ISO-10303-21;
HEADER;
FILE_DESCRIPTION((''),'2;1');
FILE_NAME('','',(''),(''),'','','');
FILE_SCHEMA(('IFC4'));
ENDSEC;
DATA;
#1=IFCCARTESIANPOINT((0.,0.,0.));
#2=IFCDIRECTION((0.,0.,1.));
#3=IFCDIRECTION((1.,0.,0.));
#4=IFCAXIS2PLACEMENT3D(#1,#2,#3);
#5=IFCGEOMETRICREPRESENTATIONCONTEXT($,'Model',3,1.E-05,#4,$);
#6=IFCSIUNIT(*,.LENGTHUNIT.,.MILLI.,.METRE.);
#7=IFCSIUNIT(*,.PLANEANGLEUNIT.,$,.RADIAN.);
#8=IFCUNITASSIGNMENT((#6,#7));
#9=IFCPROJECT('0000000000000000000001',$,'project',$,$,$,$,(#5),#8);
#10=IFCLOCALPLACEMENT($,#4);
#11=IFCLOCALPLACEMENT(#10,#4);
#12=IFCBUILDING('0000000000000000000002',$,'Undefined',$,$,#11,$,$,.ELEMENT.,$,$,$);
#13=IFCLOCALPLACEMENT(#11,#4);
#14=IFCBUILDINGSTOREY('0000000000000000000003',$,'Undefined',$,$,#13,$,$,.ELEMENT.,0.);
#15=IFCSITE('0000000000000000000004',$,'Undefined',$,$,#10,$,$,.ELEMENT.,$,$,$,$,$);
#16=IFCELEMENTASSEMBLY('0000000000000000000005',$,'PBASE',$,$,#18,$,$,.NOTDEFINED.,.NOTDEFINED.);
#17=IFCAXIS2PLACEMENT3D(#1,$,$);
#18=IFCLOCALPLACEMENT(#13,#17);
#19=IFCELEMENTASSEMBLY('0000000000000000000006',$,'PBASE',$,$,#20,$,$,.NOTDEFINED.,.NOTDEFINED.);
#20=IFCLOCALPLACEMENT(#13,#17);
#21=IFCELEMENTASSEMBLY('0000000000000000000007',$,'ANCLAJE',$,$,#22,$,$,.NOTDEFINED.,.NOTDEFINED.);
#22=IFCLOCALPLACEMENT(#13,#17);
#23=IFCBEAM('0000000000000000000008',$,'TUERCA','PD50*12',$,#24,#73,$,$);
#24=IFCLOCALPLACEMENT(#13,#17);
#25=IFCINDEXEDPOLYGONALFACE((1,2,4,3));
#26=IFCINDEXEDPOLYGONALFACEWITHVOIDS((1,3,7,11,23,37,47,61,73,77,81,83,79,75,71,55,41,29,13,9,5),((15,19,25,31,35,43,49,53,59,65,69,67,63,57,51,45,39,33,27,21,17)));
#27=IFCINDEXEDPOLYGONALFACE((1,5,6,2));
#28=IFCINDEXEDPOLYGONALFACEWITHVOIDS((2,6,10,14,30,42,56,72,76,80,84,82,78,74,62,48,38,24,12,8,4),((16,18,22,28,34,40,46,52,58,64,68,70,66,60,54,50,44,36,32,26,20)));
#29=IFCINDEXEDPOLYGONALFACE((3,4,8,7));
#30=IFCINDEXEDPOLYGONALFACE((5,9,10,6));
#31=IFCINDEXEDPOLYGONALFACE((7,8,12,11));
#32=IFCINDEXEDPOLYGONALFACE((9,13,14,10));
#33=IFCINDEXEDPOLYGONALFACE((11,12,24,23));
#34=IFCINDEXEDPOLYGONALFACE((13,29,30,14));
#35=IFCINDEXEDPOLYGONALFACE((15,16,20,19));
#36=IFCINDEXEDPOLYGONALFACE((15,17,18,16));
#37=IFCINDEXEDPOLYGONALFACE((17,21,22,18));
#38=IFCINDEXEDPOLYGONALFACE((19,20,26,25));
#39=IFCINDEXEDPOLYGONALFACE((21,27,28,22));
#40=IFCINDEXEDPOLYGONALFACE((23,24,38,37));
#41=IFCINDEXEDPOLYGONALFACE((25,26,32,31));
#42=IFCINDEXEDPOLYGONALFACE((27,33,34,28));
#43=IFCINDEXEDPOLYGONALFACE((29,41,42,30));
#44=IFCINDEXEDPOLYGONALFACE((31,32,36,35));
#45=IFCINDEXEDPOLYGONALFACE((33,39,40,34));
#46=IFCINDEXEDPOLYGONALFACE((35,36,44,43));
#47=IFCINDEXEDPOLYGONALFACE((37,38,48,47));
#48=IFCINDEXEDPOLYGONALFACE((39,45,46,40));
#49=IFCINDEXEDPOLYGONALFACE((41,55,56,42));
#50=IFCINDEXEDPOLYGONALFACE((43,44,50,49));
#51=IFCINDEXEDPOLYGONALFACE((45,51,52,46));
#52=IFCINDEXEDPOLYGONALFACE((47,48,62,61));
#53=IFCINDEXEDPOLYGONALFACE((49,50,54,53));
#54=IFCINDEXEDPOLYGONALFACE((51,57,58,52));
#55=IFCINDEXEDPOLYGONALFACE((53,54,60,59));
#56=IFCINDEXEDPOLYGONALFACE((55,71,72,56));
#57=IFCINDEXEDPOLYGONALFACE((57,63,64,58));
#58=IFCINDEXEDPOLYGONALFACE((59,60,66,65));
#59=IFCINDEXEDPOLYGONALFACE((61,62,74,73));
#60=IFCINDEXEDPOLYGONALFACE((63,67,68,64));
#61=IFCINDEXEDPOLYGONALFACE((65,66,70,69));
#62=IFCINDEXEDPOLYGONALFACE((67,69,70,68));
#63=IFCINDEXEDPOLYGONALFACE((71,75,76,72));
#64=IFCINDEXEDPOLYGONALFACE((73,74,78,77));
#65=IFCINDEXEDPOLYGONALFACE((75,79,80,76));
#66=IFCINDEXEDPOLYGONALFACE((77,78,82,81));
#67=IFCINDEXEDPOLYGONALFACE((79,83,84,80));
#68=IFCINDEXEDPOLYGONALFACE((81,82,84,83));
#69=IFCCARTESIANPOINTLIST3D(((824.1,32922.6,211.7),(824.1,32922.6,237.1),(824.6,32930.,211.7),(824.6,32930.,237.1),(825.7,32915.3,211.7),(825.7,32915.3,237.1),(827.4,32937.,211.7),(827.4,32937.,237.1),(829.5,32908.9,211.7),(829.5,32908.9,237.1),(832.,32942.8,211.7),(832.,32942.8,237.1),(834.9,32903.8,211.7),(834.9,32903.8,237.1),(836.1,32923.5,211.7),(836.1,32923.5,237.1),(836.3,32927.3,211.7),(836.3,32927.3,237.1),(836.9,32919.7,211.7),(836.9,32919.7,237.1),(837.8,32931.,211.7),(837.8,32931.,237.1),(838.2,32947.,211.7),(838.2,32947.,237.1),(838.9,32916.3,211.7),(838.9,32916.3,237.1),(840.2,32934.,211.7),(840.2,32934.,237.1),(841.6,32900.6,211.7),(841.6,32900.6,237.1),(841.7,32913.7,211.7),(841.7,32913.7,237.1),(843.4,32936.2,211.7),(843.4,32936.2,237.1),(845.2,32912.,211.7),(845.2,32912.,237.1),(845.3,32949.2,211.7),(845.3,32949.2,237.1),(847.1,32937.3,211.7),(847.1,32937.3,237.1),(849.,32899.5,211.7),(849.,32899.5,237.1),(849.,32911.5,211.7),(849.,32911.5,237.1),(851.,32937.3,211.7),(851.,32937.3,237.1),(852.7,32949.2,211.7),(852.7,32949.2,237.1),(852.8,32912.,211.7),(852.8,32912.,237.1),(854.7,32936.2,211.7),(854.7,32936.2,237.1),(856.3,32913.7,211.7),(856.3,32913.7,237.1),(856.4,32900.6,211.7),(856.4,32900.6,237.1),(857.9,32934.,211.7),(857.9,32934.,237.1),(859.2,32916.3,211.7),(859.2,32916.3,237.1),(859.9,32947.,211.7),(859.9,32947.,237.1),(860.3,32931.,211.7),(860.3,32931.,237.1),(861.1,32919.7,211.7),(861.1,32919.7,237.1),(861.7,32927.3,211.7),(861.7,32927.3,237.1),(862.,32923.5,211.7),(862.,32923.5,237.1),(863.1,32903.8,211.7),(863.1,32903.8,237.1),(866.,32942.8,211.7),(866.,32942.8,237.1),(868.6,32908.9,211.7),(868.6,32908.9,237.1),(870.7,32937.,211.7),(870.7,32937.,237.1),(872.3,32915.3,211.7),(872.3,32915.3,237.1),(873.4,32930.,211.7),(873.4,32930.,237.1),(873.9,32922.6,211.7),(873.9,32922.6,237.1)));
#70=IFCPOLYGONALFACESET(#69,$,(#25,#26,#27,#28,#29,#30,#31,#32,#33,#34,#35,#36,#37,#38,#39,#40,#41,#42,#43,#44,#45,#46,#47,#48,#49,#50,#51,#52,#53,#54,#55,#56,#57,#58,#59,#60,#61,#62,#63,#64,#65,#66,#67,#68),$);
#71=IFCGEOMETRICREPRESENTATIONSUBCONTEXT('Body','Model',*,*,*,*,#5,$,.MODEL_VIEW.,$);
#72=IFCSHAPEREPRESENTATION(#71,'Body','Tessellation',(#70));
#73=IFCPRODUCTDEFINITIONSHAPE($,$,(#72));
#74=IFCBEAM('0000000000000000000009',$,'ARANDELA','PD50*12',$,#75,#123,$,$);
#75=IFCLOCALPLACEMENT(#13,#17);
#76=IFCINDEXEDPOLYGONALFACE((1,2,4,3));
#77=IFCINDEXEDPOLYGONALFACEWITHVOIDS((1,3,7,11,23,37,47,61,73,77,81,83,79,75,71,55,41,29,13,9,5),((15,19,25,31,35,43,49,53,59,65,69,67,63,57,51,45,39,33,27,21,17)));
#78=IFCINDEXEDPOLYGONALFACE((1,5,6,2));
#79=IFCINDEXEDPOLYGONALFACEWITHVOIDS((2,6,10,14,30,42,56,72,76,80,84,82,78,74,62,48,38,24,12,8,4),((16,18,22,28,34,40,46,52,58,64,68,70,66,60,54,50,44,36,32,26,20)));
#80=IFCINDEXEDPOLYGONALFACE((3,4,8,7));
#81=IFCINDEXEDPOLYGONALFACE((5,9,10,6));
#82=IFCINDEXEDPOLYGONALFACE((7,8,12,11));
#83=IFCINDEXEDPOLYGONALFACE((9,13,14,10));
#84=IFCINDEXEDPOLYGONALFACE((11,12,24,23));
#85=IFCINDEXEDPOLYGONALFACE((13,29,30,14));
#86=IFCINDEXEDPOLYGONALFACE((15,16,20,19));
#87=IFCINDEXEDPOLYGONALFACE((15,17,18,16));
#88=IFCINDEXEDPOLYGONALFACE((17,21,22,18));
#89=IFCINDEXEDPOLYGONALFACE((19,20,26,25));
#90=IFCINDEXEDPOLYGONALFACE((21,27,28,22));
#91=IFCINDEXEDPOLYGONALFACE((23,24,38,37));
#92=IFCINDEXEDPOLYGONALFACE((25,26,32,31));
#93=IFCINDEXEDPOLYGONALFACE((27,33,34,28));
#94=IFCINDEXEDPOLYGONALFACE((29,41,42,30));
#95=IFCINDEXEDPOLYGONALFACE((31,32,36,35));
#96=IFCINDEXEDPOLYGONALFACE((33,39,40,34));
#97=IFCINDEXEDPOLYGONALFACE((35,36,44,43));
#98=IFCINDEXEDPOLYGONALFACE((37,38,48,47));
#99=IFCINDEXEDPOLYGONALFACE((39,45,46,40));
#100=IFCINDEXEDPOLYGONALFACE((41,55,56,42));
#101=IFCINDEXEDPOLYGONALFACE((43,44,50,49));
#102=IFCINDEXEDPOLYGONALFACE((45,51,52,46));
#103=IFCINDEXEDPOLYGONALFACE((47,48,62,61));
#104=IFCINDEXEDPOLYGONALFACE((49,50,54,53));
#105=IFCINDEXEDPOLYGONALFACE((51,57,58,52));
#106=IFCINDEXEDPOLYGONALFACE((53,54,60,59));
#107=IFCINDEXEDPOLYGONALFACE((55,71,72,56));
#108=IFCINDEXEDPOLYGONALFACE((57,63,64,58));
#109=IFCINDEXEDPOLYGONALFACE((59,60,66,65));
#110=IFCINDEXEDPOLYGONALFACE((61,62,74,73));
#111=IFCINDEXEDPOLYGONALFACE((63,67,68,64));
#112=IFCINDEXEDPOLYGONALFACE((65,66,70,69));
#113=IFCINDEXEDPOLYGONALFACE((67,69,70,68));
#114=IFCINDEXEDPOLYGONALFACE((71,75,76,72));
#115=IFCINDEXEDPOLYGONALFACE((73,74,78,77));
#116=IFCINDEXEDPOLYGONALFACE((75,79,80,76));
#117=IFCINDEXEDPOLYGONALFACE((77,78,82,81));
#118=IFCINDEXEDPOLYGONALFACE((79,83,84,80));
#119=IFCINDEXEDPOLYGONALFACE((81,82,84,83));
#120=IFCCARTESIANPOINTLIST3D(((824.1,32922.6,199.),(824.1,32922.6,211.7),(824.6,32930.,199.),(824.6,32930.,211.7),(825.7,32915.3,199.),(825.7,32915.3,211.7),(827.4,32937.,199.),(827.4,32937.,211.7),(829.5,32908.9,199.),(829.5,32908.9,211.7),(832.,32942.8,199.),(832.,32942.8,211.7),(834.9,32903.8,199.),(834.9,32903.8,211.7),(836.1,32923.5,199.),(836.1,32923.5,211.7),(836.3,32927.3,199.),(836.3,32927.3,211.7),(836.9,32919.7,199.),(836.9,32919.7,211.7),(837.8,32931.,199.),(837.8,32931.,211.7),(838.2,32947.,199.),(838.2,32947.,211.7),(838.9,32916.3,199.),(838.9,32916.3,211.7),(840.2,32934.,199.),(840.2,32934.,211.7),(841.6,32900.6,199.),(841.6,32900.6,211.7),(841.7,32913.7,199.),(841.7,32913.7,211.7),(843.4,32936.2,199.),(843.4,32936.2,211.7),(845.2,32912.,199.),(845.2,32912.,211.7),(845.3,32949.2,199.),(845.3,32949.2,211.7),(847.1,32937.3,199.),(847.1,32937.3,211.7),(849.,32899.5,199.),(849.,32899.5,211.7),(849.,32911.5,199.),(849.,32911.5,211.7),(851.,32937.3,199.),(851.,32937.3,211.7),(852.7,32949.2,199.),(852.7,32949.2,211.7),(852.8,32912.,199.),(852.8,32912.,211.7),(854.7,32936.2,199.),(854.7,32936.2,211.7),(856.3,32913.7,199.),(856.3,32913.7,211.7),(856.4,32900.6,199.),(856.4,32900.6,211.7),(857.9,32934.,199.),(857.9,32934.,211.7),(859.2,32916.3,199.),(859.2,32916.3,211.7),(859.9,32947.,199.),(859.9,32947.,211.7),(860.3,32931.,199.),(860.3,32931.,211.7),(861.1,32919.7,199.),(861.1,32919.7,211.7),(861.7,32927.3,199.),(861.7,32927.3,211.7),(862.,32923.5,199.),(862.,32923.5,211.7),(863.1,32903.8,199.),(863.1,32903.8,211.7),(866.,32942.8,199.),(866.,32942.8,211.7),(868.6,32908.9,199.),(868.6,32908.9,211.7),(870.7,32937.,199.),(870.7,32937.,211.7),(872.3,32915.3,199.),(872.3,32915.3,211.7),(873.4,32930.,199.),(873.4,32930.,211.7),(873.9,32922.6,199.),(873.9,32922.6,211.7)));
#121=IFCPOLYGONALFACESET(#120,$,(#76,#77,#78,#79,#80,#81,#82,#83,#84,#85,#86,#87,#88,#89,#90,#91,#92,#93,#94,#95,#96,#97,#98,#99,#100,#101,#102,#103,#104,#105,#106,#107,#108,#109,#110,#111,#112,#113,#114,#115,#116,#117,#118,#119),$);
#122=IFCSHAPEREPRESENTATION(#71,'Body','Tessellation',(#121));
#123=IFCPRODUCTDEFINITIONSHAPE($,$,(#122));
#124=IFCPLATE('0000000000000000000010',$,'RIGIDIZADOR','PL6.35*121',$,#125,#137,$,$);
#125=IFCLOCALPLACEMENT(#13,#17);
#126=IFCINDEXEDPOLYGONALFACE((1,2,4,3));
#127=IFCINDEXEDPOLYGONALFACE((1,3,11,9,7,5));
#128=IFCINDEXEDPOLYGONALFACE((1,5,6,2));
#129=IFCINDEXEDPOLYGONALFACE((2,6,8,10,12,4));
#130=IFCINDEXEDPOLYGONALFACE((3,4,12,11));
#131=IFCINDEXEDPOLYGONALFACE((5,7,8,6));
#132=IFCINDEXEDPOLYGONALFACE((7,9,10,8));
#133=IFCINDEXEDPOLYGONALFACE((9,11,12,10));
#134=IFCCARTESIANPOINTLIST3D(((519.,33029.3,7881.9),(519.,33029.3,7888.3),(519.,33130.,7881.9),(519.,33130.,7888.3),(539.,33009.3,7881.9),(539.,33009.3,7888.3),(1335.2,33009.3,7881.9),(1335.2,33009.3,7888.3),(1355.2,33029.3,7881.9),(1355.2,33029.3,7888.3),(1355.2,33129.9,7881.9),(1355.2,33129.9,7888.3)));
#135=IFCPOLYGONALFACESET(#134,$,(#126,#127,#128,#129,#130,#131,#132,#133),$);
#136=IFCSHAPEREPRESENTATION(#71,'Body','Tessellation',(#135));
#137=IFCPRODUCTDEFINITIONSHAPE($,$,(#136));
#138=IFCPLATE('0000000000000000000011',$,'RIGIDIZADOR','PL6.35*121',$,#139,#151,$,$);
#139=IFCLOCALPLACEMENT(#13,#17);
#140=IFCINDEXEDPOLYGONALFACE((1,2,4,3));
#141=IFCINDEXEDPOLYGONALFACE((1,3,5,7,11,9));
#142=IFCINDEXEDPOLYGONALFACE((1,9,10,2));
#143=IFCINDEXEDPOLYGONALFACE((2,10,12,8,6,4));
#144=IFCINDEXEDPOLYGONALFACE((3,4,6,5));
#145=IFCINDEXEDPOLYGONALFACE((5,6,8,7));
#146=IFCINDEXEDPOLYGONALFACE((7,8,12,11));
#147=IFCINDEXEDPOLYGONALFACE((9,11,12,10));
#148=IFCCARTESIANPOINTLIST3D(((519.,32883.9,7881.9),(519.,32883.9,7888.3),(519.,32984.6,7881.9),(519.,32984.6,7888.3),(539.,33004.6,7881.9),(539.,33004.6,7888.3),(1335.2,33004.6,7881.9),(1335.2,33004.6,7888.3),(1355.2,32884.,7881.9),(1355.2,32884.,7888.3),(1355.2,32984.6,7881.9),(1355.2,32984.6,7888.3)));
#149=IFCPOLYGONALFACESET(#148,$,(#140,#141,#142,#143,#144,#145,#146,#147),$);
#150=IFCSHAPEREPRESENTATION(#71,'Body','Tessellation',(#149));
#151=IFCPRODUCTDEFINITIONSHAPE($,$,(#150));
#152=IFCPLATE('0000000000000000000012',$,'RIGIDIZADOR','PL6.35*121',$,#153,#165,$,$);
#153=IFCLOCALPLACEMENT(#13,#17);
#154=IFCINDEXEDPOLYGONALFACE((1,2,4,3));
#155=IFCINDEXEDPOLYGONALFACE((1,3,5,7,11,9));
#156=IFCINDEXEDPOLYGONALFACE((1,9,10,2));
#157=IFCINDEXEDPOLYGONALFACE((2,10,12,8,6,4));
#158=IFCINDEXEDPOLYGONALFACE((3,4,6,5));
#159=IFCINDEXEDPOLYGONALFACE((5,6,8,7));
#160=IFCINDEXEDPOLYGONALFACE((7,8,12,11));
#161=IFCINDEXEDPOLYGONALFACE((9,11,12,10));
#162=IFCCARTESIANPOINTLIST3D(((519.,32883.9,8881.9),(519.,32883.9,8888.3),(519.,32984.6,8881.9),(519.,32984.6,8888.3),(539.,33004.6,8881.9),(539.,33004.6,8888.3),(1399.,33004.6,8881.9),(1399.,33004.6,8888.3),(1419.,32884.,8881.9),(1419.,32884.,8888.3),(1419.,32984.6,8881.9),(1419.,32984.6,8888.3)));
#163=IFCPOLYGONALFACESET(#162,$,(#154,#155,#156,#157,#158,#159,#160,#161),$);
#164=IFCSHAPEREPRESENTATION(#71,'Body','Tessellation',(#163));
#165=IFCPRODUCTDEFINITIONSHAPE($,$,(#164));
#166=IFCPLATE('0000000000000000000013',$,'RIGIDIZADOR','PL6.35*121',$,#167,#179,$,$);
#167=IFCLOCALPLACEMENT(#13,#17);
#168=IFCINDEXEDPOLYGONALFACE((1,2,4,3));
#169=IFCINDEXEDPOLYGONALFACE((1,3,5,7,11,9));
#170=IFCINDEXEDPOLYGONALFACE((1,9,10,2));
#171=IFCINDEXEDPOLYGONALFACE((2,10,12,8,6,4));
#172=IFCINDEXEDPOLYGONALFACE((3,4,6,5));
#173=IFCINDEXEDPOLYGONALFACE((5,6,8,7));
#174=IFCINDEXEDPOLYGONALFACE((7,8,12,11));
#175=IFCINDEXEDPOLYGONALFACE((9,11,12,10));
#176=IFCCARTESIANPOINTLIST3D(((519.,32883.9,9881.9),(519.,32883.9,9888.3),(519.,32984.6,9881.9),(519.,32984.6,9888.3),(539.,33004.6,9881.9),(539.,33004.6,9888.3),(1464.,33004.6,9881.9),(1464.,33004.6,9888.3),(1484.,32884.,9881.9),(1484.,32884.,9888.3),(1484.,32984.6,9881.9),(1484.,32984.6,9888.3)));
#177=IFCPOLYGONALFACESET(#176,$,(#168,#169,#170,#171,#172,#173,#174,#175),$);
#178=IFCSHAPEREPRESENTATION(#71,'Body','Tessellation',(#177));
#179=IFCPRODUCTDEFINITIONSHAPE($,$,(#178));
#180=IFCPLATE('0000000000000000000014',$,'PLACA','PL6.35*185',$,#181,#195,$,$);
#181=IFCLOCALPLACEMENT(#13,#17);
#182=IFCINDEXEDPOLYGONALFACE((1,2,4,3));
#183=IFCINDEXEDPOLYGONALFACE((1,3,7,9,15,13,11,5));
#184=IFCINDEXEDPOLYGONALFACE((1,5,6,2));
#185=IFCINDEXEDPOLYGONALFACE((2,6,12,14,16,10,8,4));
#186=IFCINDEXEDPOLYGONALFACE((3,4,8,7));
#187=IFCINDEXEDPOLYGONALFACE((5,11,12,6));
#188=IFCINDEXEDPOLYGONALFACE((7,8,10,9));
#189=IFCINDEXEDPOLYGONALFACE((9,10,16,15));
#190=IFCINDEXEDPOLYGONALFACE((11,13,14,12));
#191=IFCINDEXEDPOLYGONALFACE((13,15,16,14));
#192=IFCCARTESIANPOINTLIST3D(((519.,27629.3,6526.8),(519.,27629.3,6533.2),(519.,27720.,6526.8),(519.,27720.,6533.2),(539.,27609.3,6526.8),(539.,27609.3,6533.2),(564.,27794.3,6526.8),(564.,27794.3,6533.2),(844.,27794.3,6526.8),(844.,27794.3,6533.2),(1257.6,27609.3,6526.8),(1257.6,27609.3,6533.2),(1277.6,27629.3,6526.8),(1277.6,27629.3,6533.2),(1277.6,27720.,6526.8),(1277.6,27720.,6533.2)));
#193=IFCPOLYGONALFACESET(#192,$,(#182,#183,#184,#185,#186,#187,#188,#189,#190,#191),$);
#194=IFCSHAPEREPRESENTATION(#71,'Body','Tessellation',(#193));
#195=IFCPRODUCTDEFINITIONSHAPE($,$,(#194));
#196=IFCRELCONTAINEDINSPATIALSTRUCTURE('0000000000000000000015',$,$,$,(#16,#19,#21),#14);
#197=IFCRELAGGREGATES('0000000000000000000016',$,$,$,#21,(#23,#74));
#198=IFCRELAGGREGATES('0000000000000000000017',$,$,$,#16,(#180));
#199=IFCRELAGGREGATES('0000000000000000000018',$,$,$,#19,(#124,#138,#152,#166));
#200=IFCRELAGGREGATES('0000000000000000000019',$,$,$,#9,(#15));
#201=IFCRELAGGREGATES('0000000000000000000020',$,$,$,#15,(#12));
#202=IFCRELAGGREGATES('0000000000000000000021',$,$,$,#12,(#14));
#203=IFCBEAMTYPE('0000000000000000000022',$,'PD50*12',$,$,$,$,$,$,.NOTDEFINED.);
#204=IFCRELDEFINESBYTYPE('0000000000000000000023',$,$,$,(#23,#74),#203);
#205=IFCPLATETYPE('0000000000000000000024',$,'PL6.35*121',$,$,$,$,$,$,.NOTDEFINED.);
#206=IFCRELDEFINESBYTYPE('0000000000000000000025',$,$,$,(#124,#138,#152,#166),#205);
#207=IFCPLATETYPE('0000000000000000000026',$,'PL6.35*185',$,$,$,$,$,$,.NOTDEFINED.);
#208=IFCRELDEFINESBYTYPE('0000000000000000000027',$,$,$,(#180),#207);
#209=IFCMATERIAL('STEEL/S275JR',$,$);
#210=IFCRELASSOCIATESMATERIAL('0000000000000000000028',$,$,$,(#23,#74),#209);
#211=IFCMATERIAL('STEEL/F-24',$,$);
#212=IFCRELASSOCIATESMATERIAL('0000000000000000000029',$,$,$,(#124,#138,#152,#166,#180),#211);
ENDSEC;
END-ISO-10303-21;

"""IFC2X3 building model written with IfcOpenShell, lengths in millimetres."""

from ifc_helpers import new_model, si_unit, frame, origin_with_axes, origin_2d_with_axis, place, context, subcontext, project, spatial, polyline, hollow_circle, outline, extrude, material, type_object, element, aggregate, save


model = new_model("IFC2X3")

# Units and contexts
model_context = context("Model", 3, precision=1e-05, world=origin_with_axes())
body_context = subcontext(model_context, "Body", "Model", "MODEL_VIEW")
ifc_project = project(units=[si_unit("LENGTHUNIT", "METRE", prefix="MILLI"), si_unit("PLANEANGLEUNIT", "RADIAN")], contexts=[model_context])

# Site, building, storey
site_placement = place(None, origin_with_axes())
site = spatial("IfcSite", under=ifc_project, at=site_placement, Name="Undefined", CompositionType="ELEMENT")
building_placement = place(site_placement, origin_with_axes())
building = spatial("IfcBuilding", under=site, at=building_placement, Name="Undefined", CompositionType="ELEMENT")
storey_placement = place(building_placement, origin_with_axes())
storey = spatial("IfcBuildingStorey", under=building, at=storey_placement, Name="Undefined", CompositionType="ELEMENT", Elevation=0.0)

# Shared definitions
ifc_material_1 = material(Name="STEEL/F-24")

# Element assemblies
assembly_1_placement = place(storey_placement, origin_with_axes())
assembly_1 = element("IfcElementAssembly", 1, at=assembly_1_placement, inside=storey, Name="PBASE", AssemblyPlace="NOTDEFINED", PredefinedType="NOTDEFINED")
assembly_2_placement = place(storey_placement, origin_with_axes())
assembly_2 = element("IfcElementAssembly", 2, at=assembly_2_placement, inside=storey, Name="PBASE", AssemblyPlace="NOTDEFINED", PredefinedType="NOTDEFINED")

# Element assembly, beams
assembly_3_placement = place(storey_placement, origin_with_axes())
assembly_3 = element("IfcElementAssembly", 3, at=assembly_3_placement, inside=storey, Name="ANCLAJE", AssemblyPlace="NOTDEFINED", PredefinedType="NOTDEFINED")
ifc_material_2 = material(Name="STEEL/S275JR")
beam_type_1 = type_object("IfcBeamType", Name="PD50*12", PredefinedType="NOTDEFINED")
beam_1_placement = place(assembly_3_placement, frame((849.0, 32924.5, 237.1), z_axis=(1.0, 0.0, 0.0), x_axis=(0.0, 0.0, -1.0)))
beam_1 = element("IfcBeam", 4, at=beam_1_placement, type_object=beam_type_1, material=ifc_material_2, Name="TUERCA", Description="PD50*12", context=body_context, shape_type="SweptSolid", body=[
    extrude(hollow_circle(Radius=25.0, WallThickness=12.0, at=origin_2d_with_axis()), frame((25.4, 0.0, 0.0), z_axis=(-1.0, 0.0, 0.0), x_axis=(0.0, -1.0, 0.0)), (0.0, 0.0, 1.0), 25.4),
])
beam_2_placement = place(assembly_3_placement, frame((849.0, 32924.5, 211.7), z_axis=(1.0, 0.0, 0.0), x_axis=(0.0, 0.0, -1.0)))
beam_2 = element("IfcBeam", 5, at=beam_2_placement, type_object=beam_type_1, material=ifc_material_2, Name="ARANDELA", Description="PD50*12", context=body_context, shape_type="SweptSolid", body=[
    extrude(hollow_circle(Radius=25.0, WallThickness=12.0, at=origin_2d_with_axis()), frame((12.7, 0.0, 0.0), z_axis=(-1.0, 0.0, 0.0), x_axis=(0.0, -1.0, 0.0)), (0.0, 0.0, 1.0), 12.7),
])
aggregate(assembly_3, [beam_1, beam_2])

# Plates
plate_type_1 = type_object("IfcPlateType", Name="PL6.35*121", PredefinedType="NOTDEFINED")
plate_1_placement = place(assembly_2_placement, frame((519.0, 33009.3, 7885.1), z_axis=(0.0, 0.0, -1.0), x_axis=(0.0, 1.0, 0.0)))
plate_1 = element("IfcPlate", 6, at=plate_1_placement, type_object=plate_type_1, material=ifc_material_1, Name="RIGIDIZADOR", Description="PL6.35*121", context=body_context, shape_type="SweptSolid", body=[
    extrude(outline(polyline([(0.0, 20.0), (20.0, 0.0), (120.6, 0.0), (120.6, 836.2), (20.0, 836.2), (0.0, 816.2), (0.0, 20.0)])), frame((0.0, 0.0, -3.2), z_axis=(0.0, 0.0, 1.0), x_axis=(1.0, 0.0, 0.0)), (0.0, 0.0, 1.0), 6.4),
])
plate_2_placement = place(assembly_2_placement, frame((519.0, 33004.6, 7885.1), z_axis=(0.0, 0.0, 1.0), x_axis=(0.0, -1.0, 0.0)))
plate_2 = element("IfcPlate", 7, at=plate_2_placement, type_object=plate_type_1, material=ifc_material_1, Name="RIGIDIZADOR", Description="PL6.35*121", context=body_context, shape_type="SweptSolid", body=[
    extrude(outline(polyline([(0.0, 20.0), (20.0, 0.0), (120.6, 0.0), (120.6, 836.2), (20.0, 836.2), (0.0, 816.2), (0.0, 20.0)])), frame((0.0, 0.0, -3.2), z_axis=(0.0, 0.0, 1.0), x_axis=(1.0, 0.0, 0.0)), (0.0, 0.0, 1.0), 6.4),
])
plate_3_placement = place(assembly_2_placement, frame((519.0, 33004.6, 8885.1), z_axis=(0.0, 0.0, 1.0), x_axis=(0.0, -1.0, 0.0)))
plate_3 = element("IfcPlate", 8, at=plate_3_placement, type_object=plate_type_1, material=ifc_material_1, Name="RIGIDIZADOR", Description="PL6.35*121", context=body_context, shape_type="SweptSolid", body=[
    extrude(outline(polyline([(0.0, 20.0), (20.0, 0.0), (120.6, 0.0), (120.6, 900.0), (20.0, 900.0), (0.0, 880.0), (0.0, 20.0)])), frame((0.0, 0.0, -3.2), z_axis=(0.0, 0.0, 1.0), x_axis=(1.0, 0.0, 0.0)), (0.0, 0.0, 1.0), 6.4),
])
plate_4_placement = place(assembly_2_placement, frame((519.0, 33004.6, 9885.1), z_axis=(0.0, 0.0, 1.0), x_axis=(0.0, -1.0, 0.0)))
plate_4 = element("IfcPlate", 9, at=plate_4_placement, type_object=plate_type_1, material=ifc_material_1, Name="RIGIDIZADOR", Description="PL6.35*121", context=body_context, shape_type="SweptSolid", body=[
    extrude(outline(polyline([(0.0, 20.0), (20.0, 0.0), (120.6, 0.0), (120.6, 965.0), (20.0, 965.0), (0.0, 945.0), (0.0, 20.0)])), frame((0.0, 0.0, -3.2), z_axis=(0.0, 0.0, 1.0), x_axis=(1.0, 0.0, 0.0)), (0.0, 0.0, 1.0), 6.4),
])
plate_type_2 = type_object("IfcPlateType", Name="PL6.35*185", PredefinedType="NOTDEFINED")
plate_5_placement = place(assembly_1_placement, frame((519.0, 27720.0, 6530.0), z_axis=(-0.000012, 0.0, 1.0), x_axis=(0.0, -1.0, 0.0)))
plate_5 = element("IfcPlate", 10, at=plate_5_placement, type_object=plate_type_2, material=ifc_material_1, Name="PLACA", Description="PL6.35*185", context=body_context, shape_type="SweptSolid", body=[
    extrude(outline(polyline([(0.0, 0.0), (90.6, 0.0), (110.6, 20.0), (110.6, 738.6), (90.6, 758.6), (0.0, 758.6), (-74.3, 325.0), (-74.3, 45.0), (0.0, 0.0)])), frame((0.0, 0.0, -3.2), z_axis=(0.0, 0.0, 1.0), x_axis=(1.0, 0.0, 0.0)), (0.0, 0.0, 1.0), 6.4),
])

aggregate(assembly_1, [plate_5])
aggregate(assembly_2, [plate_1, plate_2, plate_3, plate_4])

save(model, "model.ifc")
